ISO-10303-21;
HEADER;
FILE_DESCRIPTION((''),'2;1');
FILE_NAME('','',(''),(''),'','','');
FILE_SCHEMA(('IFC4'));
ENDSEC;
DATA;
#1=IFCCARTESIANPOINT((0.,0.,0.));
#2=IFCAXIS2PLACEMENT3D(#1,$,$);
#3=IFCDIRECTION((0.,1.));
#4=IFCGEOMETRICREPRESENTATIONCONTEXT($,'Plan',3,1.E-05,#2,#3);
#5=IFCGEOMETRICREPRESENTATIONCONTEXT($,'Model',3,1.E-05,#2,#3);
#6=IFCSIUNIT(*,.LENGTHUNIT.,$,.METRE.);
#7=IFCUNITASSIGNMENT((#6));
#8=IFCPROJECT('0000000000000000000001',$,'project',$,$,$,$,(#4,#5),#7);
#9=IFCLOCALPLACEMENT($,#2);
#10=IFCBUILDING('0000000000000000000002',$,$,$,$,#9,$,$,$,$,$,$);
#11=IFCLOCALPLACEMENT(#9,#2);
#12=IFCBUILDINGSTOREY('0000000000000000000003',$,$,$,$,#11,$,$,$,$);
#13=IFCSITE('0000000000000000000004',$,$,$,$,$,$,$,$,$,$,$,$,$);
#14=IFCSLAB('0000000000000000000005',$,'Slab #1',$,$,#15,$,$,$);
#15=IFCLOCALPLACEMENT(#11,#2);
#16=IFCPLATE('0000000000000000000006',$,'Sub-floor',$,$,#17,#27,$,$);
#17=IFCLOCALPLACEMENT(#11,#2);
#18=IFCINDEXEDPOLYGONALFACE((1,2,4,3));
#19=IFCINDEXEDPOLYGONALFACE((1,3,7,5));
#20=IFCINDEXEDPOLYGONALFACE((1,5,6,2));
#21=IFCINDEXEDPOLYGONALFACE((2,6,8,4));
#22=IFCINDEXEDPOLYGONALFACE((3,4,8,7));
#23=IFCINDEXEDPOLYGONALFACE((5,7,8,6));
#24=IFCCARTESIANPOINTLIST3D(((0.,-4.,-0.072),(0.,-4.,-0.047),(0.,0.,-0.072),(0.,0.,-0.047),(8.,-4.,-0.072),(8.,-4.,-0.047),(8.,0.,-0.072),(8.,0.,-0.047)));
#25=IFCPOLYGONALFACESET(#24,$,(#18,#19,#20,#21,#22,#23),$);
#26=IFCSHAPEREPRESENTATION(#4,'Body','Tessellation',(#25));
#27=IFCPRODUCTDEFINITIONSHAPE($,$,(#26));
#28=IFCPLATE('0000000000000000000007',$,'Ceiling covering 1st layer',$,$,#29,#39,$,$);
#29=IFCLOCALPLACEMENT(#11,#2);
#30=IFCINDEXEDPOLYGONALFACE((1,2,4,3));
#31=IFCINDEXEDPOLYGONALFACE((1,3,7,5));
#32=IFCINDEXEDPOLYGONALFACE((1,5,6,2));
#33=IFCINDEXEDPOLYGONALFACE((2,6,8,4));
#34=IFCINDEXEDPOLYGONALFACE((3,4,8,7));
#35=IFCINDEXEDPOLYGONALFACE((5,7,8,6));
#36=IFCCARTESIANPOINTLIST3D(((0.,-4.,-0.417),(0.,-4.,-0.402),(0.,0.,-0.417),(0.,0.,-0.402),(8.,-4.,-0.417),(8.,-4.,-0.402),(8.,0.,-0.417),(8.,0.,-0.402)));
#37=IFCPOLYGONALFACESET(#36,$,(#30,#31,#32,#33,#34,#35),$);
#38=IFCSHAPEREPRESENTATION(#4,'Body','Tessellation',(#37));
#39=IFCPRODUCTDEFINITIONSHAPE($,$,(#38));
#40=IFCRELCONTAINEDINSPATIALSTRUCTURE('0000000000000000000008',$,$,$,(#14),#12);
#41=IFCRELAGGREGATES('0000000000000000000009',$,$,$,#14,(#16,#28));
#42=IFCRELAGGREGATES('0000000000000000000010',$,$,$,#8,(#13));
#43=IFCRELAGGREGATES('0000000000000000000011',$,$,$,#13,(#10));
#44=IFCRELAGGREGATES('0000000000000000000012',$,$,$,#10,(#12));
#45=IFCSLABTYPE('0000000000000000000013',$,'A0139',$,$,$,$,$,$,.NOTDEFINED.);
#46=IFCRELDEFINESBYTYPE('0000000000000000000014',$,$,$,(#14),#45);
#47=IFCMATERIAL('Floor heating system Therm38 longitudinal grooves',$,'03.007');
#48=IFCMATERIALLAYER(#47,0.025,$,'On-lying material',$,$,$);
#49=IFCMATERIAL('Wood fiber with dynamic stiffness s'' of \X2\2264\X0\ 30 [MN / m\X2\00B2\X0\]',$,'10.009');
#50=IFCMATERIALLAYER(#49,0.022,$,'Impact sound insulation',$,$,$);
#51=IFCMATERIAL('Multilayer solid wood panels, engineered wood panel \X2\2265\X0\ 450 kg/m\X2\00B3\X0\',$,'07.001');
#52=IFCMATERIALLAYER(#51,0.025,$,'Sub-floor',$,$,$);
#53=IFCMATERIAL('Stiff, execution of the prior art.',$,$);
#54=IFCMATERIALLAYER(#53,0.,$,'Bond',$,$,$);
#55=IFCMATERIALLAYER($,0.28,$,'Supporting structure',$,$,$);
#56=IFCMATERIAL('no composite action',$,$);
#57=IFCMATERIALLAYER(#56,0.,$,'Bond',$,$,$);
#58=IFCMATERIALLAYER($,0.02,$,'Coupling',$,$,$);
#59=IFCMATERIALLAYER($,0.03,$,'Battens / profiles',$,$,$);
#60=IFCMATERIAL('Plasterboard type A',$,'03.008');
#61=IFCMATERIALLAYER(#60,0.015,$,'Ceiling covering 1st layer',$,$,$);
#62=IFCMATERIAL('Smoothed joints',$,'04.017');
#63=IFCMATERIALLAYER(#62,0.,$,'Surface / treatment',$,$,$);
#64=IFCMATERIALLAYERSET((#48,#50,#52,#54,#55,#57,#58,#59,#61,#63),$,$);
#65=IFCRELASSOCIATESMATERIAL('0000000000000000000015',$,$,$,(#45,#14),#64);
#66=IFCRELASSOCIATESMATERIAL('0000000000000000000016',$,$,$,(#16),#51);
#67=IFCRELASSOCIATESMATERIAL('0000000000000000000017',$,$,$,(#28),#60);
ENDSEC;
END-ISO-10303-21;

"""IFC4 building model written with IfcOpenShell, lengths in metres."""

from ifc_helpers import new_model, si_unit, direction, frame, frame_2d, origin, place, context, project, spatial, rectangle, extrude, material, layer, layer_set, type_object, element, aggregate, save


model = new_model("IFC4")

# Units and contexts
plan_context = context("Plan", 3, precision=1e-05, world=origin(), true_north=direction((0.0, 1.0)))
model_context = context("Model", 3, precision=1e-05, world=origin(), true_north=direction((0.0, 1.0)))
ifc_project = project(units=[si_unit("LENGTHUNIT", "METRE")], contexts=[plan_context, model_context])

# Site, building, storey
site = spatial("IfcSite", under=ifc_project)
building_placement = place(None, origin())
building = spatial("IfcBuilding", under=site, at=building_placement)
storey_placement = place(building_placement, origin())
storey = spatial("IfcBuildingStorey", under=building, at=storey_placement)

# Slab, plates
ifc_material_1 = material(Name="Floor heating system Therm38 longitudinal grooves", Category="03.007")
ifc_layer_1 = layer(ifc_material_1, 0.025, Name="On-lying material")
ifc_material_2 = material(Name="Wood fiber with dynamic stiffness s' of ≤ 30 [MN / m²]", Category="10.009")
ifc_layer_2 = layer(ifc_material_2, 0.022, Name="Impact sound insulation")
ifc_material_3 = material(Name="Multilayer solid wood panels, engineered wood panel ≥ 450 kg/m³", Category="07.001")
ifc_layer_3 = layer(ifc_material_3, 0.025, Name="Sub-floor")
ifc_material_4 = material(Name="Stiff, execution of the prior art.")
ifc_layer_4 = layer(ifc_material_4, 0.0, Name="Bond")
ifc_layer_5 = layer(None, 0.28, Name="Supporting structure")
ifc_material_5 = material(Name="no composite action")
ifc_layer_6 = layer(ifc_material_5, 0.0, Name="Bond")
ifc_layer_7 = layer(None, 0.02, Name="Coupling")
ifc_layer_8 = layer(None, 0.03, Name="Battens / profiles")
ifc_material_6 = material(Name="Plasterboard type A", Category="03.008")
ifc_layer_9 = layer(ifc_material_6, 0.015, Name="Ceiling covering 1st layer")
ifc_material_7 = material(Name="Smoothed joints", Category="04.017")
ifc_layer_10 = layer(ifc_material_7, 0.0, Name="Surface / treatment")
ifc_layer_set = layer_set([ifc_layer_1, ifc_layer_2, ifc_layer_3, ifc_layer_4, ifc_layer_5, ifc_layer_6, ifc_layer_7, ifc_layer_8, ifc_layer_9, ifc_layer_10])
slab_type = type_object("IfcSlabType", Name="A0139", PredefinedType="NOTDEFINED", material=ifc_layer_set)
slab_placement = place(None, frame((0.0, 0.0, 0.0), z_axis=(0.0, 0.0, -1.0), x_axis=(1.0, 0.0, 0.0)))
slab = element("IfcSlab", 1, at=slab_placement, inside=storey, type_object=slab_type, material=ifc_layer_set, Name="Slab #1")
plate_1_placement = place(slab_placement, origin())
plate_1 = element("IfcPlate", 2, at=plate_1_placement, material=ifc_material_3, Name="Sub-floor", context=plan_context, shape_type="SweptSolid", body=[
    extrude(rectangle(XDim=8.0, YDim=4.0, at=frame_2d((4.0, 2.0), x_axis=(1.0, 0.0))), frame((0.0, 0.0, 0.047), z_axis=(0.0, 0.0, 1.0), x_axis=(1.0, 0.0, 0.0)), (0.0, 0.0, 1.0), 0.025),
])
plate_2_placement = place(slab_placement, origin())
plate_2 = element("IfcPlate", 3, at=plate_2_placement, material=ifc_material_6, Name="Ceiling covering 1st layer", context=plan_context, shape_type="SweptSolid", body=[
    extrude(rectangle(XDim=8.0, YDim=4.0, at=frame_2d((4.0, 2.0), x_axis=(1.0, 0.0))), frame((0.0, 0.0, 0.402), z_axis=(0.0, 0.0, 1.0), x_axis=(1.0, 0.0, 0.0)), (0.0, 0.0, 1.0), 0.015),
])
aggregate(slab, [plate_1, plate_2])

save(model, "model.ifc")
